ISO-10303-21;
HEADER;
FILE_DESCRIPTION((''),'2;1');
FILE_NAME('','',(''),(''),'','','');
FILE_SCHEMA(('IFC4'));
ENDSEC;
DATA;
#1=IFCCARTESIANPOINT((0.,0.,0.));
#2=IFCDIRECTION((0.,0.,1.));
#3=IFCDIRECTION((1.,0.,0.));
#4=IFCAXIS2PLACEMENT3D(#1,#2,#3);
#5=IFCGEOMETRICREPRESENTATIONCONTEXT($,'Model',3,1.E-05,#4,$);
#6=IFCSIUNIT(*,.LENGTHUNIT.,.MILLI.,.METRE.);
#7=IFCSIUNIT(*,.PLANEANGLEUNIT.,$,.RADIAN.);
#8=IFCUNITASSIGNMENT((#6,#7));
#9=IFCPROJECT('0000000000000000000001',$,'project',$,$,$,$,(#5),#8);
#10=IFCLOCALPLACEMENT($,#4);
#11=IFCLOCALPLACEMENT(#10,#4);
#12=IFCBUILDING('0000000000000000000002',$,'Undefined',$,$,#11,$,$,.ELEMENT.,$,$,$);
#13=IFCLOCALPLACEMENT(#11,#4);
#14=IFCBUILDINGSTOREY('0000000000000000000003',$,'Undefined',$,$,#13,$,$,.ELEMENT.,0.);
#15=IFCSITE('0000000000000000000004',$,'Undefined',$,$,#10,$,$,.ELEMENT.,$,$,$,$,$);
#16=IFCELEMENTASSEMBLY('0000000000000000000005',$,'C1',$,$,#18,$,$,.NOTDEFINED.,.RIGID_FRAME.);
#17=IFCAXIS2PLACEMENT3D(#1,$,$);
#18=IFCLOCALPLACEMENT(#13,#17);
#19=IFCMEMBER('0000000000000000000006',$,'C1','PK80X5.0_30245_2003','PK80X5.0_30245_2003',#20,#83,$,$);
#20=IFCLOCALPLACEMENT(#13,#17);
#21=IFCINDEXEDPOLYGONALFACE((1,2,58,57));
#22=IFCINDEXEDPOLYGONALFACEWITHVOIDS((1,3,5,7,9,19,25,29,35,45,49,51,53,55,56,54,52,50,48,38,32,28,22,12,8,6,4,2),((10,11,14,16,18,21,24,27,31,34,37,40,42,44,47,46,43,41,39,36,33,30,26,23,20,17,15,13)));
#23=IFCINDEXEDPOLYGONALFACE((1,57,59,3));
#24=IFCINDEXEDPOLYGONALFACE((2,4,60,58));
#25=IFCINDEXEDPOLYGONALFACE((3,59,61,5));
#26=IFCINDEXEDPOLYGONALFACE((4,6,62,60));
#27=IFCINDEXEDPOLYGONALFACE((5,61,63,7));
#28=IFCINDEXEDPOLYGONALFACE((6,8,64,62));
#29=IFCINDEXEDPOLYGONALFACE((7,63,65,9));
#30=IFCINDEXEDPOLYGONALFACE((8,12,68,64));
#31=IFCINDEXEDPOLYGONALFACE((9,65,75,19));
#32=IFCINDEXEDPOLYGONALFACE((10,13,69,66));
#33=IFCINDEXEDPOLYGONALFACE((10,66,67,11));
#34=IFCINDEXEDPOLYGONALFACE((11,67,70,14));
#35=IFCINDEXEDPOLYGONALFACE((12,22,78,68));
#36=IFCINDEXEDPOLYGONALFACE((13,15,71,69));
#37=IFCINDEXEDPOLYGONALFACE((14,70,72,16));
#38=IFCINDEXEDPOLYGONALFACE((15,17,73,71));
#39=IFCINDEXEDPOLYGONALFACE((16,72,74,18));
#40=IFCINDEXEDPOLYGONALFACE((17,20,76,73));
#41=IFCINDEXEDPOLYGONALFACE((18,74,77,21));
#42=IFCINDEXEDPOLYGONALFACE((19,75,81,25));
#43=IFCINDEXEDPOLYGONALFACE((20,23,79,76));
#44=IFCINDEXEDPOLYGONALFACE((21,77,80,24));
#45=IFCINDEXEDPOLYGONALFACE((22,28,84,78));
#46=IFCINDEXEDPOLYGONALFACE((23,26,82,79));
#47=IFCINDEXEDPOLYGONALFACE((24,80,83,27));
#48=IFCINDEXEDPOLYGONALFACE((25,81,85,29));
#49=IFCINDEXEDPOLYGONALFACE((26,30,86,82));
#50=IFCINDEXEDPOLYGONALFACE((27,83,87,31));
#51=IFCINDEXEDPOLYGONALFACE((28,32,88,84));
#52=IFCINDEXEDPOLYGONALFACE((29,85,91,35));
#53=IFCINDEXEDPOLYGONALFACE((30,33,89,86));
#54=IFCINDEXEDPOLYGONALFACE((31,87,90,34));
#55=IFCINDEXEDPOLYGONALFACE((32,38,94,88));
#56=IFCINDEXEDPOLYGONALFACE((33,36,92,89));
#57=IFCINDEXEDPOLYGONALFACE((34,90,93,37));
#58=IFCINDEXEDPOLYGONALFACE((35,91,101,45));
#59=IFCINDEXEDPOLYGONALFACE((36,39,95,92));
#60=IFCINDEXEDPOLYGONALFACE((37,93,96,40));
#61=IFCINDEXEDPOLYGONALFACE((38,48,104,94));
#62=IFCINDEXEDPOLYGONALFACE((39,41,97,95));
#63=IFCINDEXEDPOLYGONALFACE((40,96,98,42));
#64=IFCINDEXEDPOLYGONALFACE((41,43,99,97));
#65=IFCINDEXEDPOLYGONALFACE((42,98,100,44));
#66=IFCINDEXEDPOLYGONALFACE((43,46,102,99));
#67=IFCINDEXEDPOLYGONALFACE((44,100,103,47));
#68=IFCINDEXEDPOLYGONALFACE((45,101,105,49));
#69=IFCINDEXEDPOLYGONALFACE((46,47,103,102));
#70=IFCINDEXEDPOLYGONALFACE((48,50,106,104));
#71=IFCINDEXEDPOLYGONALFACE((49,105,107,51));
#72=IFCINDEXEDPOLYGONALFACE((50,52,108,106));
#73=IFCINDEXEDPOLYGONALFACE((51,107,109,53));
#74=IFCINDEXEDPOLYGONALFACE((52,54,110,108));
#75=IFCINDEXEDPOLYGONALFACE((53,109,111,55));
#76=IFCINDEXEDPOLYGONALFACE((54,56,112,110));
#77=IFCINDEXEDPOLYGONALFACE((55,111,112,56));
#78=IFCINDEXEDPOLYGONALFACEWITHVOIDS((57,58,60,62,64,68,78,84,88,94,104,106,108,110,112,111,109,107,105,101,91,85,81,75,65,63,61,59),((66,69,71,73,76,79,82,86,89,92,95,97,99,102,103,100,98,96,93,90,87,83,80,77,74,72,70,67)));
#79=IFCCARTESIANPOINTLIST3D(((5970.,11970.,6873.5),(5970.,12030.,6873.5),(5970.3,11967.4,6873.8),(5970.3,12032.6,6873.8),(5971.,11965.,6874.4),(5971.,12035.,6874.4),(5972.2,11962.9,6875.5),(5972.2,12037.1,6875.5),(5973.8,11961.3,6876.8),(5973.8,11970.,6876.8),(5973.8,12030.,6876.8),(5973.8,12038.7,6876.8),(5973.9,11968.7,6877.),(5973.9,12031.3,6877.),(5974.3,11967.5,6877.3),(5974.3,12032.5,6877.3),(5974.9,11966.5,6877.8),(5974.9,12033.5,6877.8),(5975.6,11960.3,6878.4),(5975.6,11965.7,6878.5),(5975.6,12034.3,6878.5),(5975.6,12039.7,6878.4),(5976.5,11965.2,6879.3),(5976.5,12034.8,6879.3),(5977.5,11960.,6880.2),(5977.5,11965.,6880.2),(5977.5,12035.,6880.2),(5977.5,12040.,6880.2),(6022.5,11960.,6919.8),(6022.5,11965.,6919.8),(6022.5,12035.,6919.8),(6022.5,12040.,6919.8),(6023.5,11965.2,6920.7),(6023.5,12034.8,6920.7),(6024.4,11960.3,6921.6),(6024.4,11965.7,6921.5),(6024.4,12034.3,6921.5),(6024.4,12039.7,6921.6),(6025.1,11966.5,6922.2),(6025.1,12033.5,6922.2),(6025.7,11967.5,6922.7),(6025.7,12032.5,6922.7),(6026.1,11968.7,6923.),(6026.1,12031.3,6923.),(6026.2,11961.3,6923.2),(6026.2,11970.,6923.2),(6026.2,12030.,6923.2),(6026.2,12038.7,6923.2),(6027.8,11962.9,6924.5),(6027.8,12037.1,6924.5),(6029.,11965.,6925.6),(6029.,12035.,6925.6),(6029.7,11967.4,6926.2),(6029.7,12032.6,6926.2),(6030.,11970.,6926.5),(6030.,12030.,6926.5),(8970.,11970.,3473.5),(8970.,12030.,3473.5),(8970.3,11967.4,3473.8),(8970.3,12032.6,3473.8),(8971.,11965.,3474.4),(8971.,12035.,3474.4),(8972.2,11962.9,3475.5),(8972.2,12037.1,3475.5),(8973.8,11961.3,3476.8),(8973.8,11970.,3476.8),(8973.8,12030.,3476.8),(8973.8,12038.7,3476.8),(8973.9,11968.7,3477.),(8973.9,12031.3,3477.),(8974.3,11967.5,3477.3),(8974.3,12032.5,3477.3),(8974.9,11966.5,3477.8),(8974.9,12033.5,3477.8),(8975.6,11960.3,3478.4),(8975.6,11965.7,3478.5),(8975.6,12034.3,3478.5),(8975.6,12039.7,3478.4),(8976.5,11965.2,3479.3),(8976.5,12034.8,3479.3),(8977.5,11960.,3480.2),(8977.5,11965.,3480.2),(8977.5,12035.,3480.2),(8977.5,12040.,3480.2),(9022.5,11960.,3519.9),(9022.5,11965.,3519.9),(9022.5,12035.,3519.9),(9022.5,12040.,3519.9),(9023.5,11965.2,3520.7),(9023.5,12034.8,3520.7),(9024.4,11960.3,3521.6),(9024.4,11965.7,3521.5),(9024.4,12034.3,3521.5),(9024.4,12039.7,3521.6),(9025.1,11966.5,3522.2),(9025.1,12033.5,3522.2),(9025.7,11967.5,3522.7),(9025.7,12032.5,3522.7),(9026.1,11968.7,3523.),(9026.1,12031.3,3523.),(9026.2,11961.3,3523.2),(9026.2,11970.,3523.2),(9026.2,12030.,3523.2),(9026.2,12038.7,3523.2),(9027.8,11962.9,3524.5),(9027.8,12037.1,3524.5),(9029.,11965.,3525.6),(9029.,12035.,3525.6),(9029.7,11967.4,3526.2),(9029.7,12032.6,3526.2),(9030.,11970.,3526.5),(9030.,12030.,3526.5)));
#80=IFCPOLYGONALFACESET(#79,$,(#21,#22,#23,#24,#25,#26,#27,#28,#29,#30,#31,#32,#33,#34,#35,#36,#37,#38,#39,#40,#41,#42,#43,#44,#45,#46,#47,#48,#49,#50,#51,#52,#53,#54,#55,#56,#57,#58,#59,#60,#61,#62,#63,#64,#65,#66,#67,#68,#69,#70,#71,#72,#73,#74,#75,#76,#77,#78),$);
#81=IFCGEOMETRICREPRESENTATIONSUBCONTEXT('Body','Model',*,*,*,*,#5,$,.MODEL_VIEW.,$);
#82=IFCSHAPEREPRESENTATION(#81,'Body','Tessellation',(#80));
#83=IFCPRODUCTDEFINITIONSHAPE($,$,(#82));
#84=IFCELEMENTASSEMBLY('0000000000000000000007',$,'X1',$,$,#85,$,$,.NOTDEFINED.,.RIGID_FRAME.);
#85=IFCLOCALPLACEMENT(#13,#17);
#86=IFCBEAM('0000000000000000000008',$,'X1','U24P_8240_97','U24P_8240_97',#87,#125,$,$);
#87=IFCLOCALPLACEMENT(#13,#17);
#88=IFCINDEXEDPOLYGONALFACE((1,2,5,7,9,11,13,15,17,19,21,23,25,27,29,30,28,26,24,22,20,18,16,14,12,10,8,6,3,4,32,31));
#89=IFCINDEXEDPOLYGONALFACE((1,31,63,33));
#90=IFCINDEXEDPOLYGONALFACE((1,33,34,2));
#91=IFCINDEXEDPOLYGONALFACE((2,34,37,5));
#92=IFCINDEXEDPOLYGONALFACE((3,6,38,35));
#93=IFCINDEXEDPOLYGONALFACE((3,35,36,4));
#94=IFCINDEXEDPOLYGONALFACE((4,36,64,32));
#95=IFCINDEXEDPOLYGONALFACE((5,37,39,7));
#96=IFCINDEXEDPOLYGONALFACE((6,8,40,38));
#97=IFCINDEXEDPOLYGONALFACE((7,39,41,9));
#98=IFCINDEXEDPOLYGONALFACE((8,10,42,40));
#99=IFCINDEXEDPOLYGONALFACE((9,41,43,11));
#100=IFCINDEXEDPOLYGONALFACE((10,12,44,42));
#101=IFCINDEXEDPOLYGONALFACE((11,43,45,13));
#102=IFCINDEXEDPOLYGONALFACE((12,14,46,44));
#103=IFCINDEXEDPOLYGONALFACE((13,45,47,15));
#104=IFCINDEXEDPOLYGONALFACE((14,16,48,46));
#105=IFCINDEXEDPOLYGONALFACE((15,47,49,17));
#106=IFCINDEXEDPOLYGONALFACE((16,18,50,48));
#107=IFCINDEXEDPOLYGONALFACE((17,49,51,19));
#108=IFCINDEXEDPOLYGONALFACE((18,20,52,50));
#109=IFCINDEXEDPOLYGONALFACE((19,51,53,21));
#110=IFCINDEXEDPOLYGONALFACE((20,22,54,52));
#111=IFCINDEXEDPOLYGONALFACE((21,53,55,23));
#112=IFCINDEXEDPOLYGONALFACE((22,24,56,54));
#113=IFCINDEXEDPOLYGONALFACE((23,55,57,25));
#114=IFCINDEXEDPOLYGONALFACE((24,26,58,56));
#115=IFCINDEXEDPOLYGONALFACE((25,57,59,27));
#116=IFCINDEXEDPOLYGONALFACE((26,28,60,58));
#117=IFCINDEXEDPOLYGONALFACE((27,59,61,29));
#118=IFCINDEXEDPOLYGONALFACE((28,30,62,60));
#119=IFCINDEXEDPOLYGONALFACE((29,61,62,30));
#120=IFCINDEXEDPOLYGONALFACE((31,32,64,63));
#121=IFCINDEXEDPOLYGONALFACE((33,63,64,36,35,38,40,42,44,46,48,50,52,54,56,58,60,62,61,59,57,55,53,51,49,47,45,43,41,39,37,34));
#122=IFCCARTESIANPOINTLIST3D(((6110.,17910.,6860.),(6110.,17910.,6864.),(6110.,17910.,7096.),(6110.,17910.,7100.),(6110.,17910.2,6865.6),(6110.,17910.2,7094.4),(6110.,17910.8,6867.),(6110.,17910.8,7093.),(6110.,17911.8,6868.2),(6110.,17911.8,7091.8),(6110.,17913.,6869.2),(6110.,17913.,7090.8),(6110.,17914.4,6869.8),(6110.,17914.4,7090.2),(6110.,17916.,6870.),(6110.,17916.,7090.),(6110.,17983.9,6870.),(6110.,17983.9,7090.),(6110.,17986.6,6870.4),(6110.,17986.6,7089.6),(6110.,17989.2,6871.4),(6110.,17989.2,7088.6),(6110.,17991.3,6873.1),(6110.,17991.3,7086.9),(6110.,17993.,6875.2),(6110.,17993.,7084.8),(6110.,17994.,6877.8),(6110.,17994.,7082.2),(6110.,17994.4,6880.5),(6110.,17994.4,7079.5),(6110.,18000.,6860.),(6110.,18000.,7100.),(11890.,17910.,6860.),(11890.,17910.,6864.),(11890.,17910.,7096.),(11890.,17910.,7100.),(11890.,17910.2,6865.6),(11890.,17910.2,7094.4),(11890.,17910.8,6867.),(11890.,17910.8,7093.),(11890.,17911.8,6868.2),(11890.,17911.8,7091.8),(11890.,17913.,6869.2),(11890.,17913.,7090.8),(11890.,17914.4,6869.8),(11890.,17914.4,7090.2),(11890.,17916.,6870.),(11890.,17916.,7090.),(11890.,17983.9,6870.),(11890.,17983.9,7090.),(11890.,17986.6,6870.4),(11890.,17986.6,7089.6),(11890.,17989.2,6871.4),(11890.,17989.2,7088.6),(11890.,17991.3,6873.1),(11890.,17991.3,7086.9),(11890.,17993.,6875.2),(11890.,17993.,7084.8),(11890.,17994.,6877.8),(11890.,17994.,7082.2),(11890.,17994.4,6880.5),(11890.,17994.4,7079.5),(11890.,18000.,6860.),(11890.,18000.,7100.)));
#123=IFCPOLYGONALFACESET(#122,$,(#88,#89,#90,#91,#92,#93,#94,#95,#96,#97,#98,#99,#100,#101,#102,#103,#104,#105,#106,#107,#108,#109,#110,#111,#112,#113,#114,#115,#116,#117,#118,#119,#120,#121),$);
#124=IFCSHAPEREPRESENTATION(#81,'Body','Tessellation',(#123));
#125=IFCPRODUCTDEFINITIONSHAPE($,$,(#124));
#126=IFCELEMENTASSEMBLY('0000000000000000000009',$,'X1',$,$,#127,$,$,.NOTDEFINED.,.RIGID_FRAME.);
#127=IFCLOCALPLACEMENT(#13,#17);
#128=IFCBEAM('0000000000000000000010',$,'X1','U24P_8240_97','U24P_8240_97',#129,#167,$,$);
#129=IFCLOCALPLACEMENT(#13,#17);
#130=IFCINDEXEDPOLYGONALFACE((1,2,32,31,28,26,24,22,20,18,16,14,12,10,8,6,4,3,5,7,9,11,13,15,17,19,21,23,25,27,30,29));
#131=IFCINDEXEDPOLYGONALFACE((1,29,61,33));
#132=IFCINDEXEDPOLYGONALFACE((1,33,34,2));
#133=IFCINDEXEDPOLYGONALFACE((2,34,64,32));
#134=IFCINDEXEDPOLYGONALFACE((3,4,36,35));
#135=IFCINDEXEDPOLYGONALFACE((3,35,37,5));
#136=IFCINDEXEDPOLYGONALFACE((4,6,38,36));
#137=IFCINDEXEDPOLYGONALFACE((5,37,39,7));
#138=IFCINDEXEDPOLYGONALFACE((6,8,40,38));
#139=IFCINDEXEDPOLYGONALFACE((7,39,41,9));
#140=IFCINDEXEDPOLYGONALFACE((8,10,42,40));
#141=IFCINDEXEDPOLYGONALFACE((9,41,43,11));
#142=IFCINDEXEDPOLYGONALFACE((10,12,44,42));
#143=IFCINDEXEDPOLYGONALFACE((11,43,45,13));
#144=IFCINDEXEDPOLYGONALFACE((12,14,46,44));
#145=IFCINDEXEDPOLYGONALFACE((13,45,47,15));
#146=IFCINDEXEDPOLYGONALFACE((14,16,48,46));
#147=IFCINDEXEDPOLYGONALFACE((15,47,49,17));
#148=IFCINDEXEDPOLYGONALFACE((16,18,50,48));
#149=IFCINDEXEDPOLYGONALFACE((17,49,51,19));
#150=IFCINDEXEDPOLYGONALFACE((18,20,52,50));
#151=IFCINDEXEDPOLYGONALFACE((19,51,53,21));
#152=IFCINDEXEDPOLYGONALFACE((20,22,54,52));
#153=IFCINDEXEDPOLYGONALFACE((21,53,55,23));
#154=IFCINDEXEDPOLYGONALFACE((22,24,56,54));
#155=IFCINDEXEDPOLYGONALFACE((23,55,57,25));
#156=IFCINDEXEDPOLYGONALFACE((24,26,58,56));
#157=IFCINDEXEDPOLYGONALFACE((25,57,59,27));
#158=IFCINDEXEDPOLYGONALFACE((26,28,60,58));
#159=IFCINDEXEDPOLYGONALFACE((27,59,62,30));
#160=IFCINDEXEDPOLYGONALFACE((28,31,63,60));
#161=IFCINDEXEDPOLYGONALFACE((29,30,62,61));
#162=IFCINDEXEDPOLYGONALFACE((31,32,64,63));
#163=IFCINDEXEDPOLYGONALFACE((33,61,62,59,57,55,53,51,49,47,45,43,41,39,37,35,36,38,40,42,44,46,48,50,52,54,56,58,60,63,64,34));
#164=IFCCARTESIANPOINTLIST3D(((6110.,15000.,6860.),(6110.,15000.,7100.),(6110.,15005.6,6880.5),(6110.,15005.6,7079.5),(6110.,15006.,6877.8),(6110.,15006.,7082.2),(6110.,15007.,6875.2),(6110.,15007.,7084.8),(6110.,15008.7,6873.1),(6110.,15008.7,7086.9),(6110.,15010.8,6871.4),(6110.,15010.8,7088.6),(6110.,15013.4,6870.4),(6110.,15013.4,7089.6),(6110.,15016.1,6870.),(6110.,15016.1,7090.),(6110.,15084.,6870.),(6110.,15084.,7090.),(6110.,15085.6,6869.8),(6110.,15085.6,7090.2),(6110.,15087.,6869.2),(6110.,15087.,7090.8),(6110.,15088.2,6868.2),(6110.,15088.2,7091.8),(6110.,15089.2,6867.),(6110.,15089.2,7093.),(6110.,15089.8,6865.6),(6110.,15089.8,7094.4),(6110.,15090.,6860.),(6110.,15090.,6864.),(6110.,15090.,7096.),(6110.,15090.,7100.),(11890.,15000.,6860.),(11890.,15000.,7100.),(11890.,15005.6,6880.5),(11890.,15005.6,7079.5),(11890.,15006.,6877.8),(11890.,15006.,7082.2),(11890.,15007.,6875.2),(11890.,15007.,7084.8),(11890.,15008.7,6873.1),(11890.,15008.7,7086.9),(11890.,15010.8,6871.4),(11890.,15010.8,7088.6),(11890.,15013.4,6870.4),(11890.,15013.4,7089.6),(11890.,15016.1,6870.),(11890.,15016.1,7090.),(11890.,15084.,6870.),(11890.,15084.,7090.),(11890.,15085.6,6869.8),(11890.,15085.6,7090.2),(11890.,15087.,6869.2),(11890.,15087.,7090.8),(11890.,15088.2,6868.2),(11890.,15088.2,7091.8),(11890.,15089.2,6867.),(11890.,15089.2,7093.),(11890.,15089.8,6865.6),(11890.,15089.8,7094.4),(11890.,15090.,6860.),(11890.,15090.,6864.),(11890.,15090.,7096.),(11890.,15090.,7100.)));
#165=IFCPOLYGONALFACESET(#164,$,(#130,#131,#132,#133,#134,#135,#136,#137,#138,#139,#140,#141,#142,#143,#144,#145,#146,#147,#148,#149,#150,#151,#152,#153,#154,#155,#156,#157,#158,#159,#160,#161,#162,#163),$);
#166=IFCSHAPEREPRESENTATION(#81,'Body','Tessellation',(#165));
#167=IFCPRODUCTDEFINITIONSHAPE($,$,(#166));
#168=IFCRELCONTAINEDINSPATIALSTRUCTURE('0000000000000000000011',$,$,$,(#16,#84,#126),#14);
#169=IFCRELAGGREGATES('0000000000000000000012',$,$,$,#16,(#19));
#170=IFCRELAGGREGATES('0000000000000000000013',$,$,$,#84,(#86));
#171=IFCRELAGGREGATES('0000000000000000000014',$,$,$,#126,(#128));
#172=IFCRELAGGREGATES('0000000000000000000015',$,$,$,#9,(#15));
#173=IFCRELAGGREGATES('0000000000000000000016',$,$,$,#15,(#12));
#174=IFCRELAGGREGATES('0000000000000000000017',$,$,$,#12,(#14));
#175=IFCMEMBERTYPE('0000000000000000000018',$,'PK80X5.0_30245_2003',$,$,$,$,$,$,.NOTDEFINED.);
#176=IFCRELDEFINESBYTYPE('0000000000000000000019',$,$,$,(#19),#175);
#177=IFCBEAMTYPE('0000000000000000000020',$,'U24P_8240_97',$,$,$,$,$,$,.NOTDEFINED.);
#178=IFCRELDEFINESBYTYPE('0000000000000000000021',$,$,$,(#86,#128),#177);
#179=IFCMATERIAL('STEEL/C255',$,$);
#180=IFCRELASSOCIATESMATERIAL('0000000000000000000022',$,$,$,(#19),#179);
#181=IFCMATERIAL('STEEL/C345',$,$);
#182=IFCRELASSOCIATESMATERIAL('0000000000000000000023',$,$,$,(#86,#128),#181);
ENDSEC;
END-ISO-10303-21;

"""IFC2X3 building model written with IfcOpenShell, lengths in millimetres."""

from ifc_helpers import new_model, si_unit, frame, origin_with_axes, origin_2d_with_axis, place, context, subcontext, project, spatial, hollow_rectangle, u_section, extrude, material, type_object, element, aggregate, save


model = new_model("IFC2X3")

# Units and contexts
model_context = context("Model", 3, precision=1e-05, world=origin_with_axes())
body_context = subcontext(model_context, "Body", "Model", "MODEL_VIEW")
ifc_project = project(units=[si_unit("LENGTHUNIT", "METRE", prefix="MILLI"), si_unit("PLANEANGLEUNIT", "RADIAN")], contexts=[model_context])

# Site, building, storey
site_placement = place(None, origin_with_axes())
site = spatial("IfcSite", under=ifc_project, at=site_placement, Name="Undefined", CompositionType="ELEMENT")
building_placement = place(site_placement, origin_with_axes())
building = spatial("IfcBuilding", under=site, at=building_placement, Name="Undefined", CompositionType="ELEMENT")
storey_placement = place(building_placement, origin_with_axes())
storey = spatial("IfcBuildingStorey", under=building, at=storey_placement, Name="Undefined", CompositionType="ELEMENT", Elevation=0.0)

# Shared definitions
ifc_material_1 = material(Name="STEEL/C345")

# Shared definitions
ifc_material_2 = material(Name="STEEL/C255")

# Element assembly, member
member_type = type_object("IfcMemberType", Name="PK80X5.0_30245_2003", PredefinedType="NOTDEFINED")
assembly_1_placement = place(storey_placement, origin_with_axes())
assembly_1 = element("IfcElementAssembly", 1, at=assembly_1_placement, inside=storey, Name="C1", AssemblyPlace="NOTDEFINED", PredefinedType="RIGID_FRAME")
member_1_placement = place(assembly_1_placement, frame((9000.0, 12000.0, 3500.0), z_axis=(-0.749838, 0.0, -0.661622), x_axis=(-0.661622, 0.0, 0.749838)))
member_1 = element("IfcMember", 2, at=member_1_placement, type_object=member_type, material=ifc_material_2, Name="C1", Description="PK80X5.0_30245_2003", ObjectType="PK80X5.0_30245_2003", context=body_context, shape_type="SweptSolid", body=[
    extrude(hollow_rectangle(XDim=80.0, YDim=80.0, WallThickness=5.0, InnerFilletRadius=5.0, OuterFilletRadius=10.0, at=origin_2d_with_axis()), frame((4534.3, 0.0, 0.0), z_axis=(-1.0, 0.0, 0.0), x_axis=(0.0, -1.0, 0.0)), (0.0, 0.0, 1.0), 4534.3),
])
aggregate(assembly_1, [member_1])

# Element assemblies, beams
assembly_2_placement = place(storey_placement, origin_with_axes())
assembly_2 = element("IfcElementAssembly", 3, at=assembly_2_placement, inside=storey, Name="X1", AssemblyPlace="NOTDEFINED", PredefinedType="RIGID_FRAME")
beam_type_1 = type_object("IfcBeamType", Name="U24P_8240_97", PredefinedType="NOTDEFINED")
beam_1_placement = place(assembly_2_placement, frame((6110.0, 17955.0, 6980.0), z_axis=(0.0, 0.0, 1.0), x_axis=(1.0, 0.0, 0.0)))
beam_1 = element("IfcBeam", 4, at=beam_1_placement, type_object=beam_type_1, material=ifc_material_1, Name="X1", Description="U24P_8240_97", ObjectType="U24P_8240_97", context=body_context, shape_type="SweptSolid", body=[
    extrude(u_section(Depth=240.0, FlangeWidth=90.0, WebThickness=5.6, FlangeThickness=10.0, FilletRadius=10.5, EdgeRadius=6.0, at=origin_2d_with_axis()), frame((5780.0, 0.0, 0.0), z_axis=(-1.0, 0.0, 0.0), x_axis=(0.0, -1.0, 0.0)), (0.0, 0.0, 1.0), 5780.0),
])
aggregate(assembly_2, [beam_1])
assembly_3_placement = place(storey_placement, origin_with_axes())
assembly_3 = element("IfcElementAssembly", 5, at=assembly_3_placement, inside=storey, Name="X1", AssemblyPlace="NOTDEFINED", PredefinedType="RIGID_FRAME")
beam_2_placement = place(assembly_3_placement, frame((6110.0, 15045.0, 6980.0), z_axis=(0.0, 0.0, -1.0), x_axis=(1.0, 0.0, 0.0)))
beam_2 = element("IfcBeam", 6, at=beam_2_placement, type_object=beam_type_1, material=ifc_material_1, Name="X1", Description="U24P_8240_97", ObjectType="U24P_8240_97", context=body_context, shape_type="SweptSolid", body=[
    extrude(u_section(Depth=240.0, FlangeWidth=90.0, WebThickness=5.6, FlangeThickness=10.0, FilletRadius=10.5, EdgeRadius=6.0, at=origin_2d_with_axis()), frame((5780.0, 0.0, 0.0), z_axis=(-1.0, 0.0, 0.0), x_axis=(0.0, -1.0, 0.0)), (0.0, 0.0, 1.0), 5780.0),
])
aggregate(assembly_3, [beam_2])

save(model, "model.ifc")
